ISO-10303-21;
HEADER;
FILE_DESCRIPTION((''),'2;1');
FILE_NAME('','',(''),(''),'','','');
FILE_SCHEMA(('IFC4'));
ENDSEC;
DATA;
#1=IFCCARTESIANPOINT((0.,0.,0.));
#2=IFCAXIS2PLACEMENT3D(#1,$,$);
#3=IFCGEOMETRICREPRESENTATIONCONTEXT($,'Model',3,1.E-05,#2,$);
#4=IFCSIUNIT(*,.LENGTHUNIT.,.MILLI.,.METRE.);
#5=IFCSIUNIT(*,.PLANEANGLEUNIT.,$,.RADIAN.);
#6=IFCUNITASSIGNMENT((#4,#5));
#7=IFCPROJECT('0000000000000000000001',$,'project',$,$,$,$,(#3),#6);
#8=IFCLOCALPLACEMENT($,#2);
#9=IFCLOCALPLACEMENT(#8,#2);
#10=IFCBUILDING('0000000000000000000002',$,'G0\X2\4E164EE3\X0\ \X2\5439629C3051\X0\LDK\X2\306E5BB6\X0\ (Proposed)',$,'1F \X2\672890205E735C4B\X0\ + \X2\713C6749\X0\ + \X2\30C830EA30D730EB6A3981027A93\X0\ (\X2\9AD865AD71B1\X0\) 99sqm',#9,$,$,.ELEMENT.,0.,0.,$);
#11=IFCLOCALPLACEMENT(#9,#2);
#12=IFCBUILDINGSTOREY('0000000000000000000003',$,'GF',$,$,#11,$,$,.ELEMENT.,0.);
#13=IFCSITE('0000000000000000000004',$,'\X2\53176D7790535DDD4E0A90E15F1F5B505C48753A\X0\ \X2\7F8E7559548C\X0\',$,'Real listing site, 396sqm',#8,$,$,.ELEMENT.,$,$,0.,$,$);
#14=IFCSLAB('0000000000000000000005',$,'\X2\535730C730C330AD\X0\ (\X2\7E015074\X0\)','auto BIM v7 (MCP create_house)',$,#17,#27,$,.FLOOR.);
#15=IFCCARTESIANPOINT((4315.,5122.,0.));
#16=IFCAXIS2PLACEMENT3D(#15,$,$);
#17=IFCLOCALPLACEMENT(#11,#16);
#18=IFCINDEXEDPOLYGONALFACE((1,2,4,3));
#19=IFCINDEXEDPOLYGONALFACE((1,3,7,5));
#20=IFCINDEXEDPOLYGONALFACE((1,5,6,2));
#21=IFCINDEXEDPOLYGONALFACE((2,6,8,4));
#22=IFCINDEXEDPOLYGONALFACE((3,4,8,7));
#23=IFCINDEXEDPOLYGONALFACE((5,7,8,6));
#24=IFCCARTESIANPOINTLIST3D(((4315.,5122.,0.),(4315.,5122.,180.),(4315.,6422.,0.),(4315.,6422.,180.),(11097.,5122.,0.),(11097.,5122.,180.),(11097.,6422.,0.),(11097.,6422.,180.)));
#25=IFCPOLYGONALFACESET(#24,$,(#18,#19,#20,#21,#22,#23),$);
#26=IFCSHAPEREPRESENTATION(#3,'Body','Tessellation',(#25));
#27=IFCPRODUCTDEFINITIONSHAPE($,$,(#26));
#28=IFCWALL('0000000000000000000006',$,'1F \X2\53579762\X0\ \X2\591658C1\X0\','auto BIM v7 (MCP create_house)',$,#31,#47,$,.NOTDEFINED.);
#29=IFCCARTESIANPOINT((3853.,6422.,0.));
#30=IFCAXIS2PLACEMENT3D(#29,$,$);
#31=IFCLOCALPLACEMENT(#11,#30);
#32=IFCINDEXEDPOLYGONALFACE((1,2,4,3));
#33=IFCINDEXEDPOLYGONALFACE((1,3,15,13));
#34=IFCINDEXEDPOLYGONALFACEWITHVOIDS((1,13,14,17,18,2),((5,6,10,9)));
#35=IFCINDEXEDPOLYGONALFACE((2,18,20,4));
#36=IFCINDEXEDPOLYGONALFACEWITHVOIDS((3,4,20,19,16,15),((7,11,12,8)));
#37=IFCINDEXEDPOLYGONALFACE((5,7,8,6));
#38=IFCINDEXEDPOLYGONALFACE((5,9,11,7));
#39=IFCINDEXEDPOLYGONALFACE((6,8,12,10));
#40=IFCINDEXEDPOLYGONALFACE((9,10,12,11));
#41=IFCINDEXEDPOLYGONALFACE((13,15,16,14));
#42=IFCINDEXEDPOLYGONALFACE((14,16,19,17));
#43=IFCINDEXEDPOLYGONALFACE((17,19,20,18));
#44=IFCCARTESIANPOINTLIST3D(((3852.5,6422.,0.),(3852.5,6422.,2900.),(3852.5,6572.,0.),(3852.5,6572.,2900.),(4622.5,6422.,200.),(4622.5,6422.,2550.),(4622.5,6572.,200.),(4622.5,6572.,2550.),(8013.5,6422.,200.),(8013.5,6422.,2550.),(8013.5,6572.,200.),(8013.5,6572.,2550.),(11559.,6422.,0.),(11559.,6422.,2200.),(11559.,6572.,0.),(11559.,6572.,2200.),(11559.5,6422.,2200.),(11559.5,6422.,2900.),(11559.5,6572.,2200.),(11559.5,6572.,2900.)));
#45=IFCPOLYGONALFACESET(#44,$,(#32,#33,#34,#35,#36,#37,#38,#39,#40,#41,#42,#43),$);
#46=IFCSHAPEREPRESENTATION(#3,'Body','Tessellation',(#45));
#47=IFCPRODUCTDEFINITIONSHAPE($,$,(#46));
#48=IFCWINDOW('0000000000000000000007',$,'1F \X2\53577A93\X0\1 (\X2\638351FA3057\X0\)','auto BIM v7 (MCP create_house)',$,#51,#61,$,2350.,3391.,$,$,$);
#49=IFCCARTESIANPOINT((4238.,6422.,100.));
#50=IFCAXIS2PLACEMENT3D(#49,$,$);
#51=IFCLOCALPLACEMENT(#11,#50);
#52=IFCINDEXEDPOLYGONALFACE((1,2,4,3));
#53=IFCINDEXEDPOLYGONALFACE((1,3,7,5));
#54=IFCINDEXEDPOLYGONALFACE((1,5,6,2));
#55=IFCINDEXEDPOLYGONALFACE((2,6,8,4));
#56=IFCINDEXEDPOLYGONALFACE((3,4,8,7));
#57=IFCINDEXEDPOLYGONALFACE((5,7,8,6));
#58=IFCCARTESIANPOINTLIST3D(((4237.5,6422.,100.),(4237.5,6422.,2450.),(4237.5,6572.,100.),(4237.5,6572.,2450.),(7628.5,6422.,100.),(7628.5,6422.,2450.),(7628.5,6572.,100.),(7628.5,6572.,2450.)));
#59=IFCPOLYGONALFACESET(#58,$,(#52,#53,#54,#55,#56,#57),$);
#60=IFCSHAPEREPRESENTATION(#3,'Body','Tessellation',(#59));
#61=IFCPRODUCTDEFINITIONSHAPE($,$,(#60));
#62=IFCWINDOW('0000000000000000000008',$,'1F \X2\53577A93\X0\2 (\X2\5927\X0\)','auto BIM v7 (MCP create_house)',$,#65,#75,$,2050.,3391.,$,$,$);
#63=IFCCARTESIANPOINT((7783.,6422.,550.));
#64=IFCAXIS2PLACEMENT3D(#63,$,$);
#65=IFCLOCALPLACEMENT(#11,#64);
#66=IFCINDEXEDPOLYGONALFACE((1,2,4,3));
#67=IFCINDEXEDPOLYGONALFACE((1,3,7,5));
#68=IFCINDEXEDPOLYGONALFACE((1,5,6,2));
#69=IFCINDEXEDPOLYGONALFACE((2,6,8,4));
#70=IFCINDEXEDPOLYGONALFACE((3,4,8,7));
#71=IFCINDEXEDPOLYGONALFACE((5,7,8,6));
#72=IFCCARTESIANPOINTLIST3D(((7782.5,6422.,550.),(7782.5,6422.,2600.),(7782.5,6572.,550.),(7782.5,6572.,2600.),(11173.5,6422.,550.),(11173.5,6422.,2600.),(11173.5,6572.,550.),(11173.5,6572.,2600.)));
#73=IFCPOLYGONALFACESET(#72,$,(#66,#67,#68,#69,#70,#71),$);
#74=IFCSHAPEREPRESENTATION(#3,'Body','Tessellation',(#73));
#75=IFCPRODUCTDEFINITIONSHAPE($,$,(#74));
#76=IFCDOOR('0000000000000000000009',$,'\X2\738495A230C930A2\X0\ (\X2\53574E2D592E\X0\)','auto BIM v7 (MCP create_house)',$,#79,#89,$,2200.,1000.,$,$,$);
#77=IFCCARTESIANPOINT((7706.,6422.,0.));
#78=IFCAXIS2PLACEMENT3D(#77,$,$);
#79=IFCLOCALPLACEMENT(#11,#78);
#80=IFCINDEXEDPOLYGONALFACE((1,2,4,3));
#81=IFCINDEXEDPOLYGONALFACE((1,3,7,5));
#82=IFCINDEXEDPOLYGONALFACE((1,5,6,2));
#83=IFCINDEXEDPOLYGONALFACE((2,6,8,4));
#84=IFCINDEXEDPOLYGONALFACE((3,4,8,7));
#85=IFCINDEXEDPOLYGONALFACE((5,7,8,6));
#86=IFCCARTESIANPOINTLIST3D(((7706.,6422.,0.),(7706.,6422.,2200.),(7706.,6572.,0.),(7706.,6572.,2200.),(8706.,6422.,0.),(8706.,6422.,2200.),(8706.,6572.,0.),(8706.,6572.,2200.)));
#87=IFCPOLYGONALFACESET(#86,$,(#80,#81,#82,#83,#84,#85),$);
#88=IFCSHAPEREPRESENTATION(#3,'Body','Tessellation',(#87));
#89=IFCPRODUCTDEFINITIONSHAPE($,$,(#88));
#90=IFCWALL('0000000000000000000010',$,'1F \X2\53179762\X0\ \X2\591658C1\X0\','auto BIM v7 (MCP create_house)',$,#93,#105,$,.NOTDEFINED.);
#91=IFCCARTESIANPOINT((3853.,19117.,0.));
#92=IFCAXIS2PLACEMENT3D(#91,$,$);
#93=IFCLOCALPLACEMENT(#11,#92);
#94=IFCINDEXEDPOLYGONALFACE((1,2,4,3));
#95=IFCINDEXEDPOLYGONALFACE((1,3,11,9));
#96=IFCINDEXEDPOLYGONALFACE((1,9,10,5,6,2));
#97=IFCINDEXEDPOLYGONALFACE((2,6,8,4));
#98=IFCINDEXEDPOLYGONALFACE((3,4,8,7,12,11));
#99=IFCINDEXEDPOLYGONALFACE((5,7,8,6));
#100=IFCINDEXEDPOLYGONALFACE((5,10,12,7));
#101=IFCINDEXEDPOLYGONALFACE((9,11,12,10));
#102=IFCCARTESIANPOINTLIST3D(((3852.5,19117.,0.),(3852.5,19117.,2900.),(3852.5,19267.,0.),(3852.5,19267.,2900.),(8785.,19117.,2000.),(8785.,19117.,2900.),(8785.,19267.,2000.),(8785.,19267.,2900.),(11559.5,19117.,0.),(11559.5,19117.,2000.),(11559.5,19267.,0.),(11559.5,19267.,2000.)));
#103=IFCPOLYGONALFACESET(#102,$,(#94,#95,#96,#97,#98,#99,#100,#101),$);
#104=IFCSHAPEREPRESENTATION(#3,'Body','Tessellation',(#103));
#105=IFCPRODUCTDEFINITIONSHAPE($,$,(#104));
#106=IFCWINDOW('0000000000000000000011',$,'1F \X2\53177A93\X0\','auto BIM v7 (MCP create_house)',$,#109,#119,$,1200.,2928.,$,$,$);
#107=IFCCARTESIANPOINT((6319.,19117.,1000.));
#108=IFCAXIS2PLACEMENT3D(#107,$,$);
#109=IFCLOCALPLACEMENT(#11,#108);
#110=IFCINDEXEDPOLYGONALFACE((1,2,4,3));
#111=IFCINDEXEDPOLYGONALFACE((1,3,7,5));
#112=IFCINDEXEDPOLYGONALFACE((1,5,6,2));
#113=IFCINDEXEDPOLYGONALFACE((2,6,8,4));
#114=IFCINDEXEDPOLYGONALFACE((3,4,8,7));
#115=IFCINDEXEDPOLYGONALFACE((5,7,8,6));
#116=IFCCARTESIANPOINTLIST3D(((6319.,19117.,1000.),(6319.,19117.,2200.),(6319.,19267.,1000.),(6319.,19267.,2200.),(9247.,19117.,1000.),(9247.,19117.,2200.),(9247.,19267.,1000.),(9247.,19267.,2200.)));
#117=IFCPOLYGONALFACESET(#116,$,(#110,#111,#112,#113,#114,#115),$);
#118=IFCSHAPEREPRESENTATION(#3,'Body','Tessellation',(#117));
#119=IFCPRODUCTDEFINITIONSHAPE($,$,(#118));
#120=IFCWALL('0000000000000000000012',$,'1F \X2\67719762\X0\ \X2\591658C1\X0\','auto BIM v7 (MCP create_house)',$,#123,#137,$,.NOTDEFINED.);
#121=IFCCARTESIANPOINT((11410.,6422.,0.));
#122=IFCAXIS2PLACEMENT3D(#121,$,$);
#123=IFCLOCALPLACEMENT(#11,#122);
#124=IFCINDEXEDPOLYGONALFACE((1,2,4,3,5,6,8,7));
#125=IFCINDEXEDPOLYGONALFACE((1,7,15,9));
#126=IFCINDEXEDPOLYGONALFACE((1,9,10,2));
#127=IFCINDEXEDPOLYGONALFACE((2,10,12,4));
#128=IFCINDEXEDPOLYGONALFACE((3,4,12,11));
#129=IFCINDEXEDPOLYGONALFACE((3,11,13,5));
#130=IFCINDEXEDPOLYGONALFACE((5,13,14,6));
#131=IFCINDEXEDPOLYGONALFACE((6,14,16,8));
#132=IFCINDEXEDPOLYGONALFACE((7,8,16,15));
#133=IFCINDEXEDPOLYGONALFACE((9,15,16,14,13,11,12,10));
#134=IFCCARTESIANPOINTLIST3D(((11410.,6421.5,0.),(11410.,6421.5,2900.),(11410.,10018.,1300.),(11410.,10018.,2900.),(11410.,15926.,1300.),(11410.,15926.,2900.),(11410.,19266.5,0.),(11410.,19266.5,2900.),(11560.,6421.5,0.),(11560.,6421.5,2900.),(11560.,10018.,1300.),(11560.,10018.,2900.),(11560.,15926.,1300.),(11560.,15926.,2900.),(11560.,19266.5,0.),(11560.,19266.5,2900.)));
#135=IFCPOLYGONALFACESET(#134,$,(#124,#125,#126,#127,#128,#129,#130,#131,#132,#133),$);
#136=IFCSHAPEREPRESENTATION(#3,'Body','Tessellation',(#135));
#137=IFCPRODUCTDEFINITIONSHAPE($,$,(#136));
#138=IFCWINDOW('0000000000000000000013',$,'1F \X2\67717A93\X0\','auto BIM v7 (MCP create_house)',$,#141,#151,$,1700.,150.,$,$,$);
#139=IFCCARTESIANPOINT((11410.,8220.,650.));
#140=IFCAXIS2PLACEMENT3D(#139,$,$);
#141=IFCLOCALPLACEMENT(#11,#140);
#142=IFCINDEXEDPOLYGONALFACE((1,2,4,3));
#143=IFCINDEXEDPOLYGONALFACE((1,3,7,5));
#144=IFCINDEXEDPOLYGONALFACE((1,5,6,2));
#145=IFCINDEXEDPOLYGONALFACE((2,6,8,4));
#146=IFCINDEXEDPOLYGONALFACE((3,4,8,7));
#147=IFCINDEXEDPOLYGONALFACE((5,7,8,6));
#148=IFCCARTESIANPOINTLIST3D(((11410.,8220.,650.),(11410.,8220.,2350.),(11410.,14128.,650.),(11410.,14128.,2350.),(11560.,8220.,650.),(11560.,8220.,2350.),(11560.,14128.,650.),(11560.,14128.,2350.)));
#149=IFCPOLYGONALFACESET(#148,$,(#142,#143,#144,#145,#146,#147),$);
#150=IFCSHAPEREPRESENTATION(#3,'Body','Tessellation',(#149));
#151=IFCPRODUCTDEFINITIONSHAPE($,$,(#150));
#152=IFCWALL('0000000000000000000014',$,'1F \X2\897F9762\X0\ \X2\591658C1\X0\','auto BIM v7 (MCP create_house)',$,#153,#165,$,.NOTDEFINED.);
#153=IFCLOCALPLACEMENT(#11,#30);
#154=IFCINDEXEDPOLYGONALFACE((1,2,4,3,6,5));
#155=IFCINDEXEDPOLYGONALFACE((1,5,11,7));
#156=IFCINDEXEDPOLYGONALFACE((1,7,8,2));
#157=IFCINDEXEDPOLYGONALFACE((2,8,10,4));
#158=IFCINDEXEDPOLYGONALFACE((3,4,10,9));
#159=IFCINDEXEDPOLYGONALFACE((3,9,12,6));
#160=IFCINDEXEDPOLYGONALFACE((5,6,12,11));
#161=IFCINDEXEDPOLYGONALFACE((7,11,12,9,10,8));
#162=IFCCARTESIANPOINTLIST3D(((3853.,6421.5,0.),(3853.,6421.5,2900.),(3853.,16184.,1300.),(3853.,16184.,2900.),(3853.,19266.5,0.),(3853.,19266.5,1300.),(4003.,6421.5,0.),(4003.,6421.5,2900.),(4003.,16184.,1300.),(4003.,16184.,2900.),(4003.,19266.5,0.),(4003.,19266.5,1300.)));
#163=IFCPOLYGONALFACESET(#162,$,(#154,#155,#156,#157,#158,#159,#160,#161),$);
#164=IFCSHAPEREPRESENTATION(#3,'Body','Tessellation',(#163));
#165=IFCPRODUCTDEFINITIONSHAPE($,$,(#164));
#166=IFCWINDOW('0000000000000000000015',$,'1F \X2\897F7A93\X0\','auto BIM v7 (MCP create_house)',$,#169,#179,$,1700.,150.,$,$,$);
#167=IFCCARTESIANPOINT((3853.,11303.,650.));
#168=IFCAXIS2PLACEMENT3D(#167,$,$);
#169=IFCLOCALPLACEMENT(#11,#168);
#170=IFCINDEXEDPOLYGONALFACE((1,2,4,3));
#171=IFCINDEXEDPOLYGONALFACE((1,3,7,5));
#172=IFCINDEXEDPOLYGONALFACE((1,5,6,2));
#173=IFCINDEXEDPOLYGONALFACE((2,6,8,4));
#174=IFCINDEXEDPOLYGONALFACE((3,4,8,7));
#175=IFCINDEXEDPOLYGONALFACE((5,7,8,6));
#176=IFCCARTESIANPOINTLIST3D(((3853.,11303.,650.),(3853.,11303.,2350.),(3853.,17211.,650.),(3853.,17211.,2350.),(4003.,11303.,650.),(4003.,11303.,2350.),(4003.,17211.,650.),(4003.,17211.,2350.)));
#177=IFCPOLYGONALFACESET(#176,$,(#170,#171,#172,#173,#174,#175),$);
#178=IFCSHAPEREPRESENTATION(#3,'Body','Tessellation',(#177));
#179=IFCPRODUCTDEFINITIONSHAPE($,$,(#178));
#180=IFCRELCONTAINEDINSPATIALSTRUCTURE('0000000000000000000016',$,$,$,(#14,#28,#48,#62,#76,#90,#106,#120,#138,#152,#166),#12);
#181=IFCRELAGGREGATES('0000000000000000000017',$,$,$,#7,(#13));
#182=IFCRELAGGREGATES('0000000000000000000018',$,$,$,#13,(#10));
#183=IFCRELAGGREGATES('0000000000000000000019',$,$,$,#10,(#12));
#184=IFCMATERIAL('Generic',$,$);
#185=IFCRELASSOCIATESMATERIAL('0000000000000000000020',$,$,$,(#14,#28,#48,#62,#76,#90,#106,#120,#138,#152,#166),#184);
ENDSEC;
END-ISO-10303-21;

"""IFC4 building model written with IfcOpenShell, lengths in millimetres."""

from ifc_helpers import new_model, si_unit, frame, frame_2d, origin, place, context, project, spatial, rectangle, extrude, material, element, fill, save


model = new_model("IFC4")

# Units and contexts
model_context = context("Model", 3, precision=1e-05, world=origin())
ifc_project = project(units=[si_unit("LENGTHUNIT", "METRE", prefix="MILLI"), si_unit("PLANEANGLEUNIT", "RADIAN")], contexts=[model_context])

# Site, building, storey
site_placement = place(None, origin())
site = spatial("IfcSite", under=ifc_project, at=site_placement, Name="北海道川上郡弟子屈町 美留和", ObjectType="Real listing site, 396sqm", CompositionType="ELEMENT", RefElevation=0.0)
building_placement = place(site_placement, origin())
building = spatial("IfcBuilding", under=site, at=building_placement, Name="G0世代 吹抜けLDKの家 (Proposed)", ObjectType="1F 木造平屋 + 焼杉 + トリプル樹脂窓 (高断熱) 99sqm", CompositionType="ELEMENT", ElevationOfRefHeight=0.0, ElevationOfTerrain=0.0)
storey_placement = place(building_placement, origin())
storey = spatial("IfcBuildingStorey", under=building, at=storey_placement, Name="GF", CompositionType="ELEMENT", Elevation=0.0)

# Slab
ifc_material = material(Name="Generic")
slab_1_placement = place(storey_placement, frame((4315.0, 5122.0, 0.0)))
element("IfcSlab", 1, at=slab_1_placement, inside=storey, material=ifc_material, Name="南デッキ (縁側)", Description="auto BIM v7 (MCP create_house)", PredefinedType="FLOOR", context=model_context, shape_type="SweptSolid", body=[
    extrude(rectangle(XDim=6782.0, YDim=1300.0, at=frame_2d((3391.0, 650.0))), frame((4315.0, 5122.0, 0.0)), (0.0, 0.0, 1.0), 180.0),
])

# Wall, openings, windows, door
wall_1_placement = place(storey_placement, frame((3853.0, 6422.0, 0.0)))
wall_1 = element("IfcWall", 2, at=wall_1_placement, inside=storey, material=ifc_material, Name="1F 南面 外壁", Description="auto BIM v7 (MCP create_house)", PredefinedType="NOTDEFINED", context=model_context, shape_type="SweptSolid", body=[
    extrude(rectangle(XDim=7707.0, YDim=150.0, at=frame_2d((3853.0, 75.0))), frame((3853.0, 6422.0, 0.0)), (0.0, 0.0, 1.0), 2900.0),
])
opening_1_placement = place(storey_placement, frame((4238.0, 6422.0, 100.0)))
opening_1 = element("IfcOpeningElement", 3, at=opening_1_placement, cuts=wall_1, PredefinedType="NOTDEFINED", context=model_context, shape_type="SweptSolid", body=[
    extrude(rectangle(XDim=3391.0, YDim=150.0, at=frame_2d((1695.0, 75.0))), frame((4238.0, 6422.0, 100.0)), (0.0, 0.0, 1.0), 2350.0),
])
opening_2_placement = place(storey_placement, frame((7783.0, 6422.0, 550.0)))
opening_2 = element("IfcOpeningElement", 4, at=opening_2_placement, cuts=wall_1, PredefinedType="NOTDEFINED", context=model_context, shape_type="SweptSolid", body=[
    extrude(rectangle(XDim=3391.0, YDim=150.0, at=frame_2d((1695.0, 75.0))), frame((7783.0, 6422.0, 550.0)), (0.0, 0.0, 1.0), 2050.0),
])
opening_3_placement = place(storey_placement, frame((7706.0, 6422.0, 0.0)))
opening_3 = element("IfcOpeningElement", 5, at=opening_3_placement, cuts=wall_1, PredefinedType="NOTDEFINED", context=model_context, shape_type="SweptSolid", body=[
    extrude(rectangle(XDim=1000.0, YDim=150.0, at=frame_2d((500.0, 75.0))), frame((7706.0, 6422.0, 0.0)), (0.0, 0.0, 1.0), 2200.0),
])
window_1_placement = place(storey_placement, frame((4238.0, 6422.0, 100.0)))
window_1 = element("IfcWindow", 6, at=window_1_placement, inside=storey, material=ifc_material, Name="1F 南窓1 (掃出し)", Description="auto BIM v7 (MCP create_house)", OverallHeight=2350.0, OverallWidth=3391.0, context=model_context, shape_type="SweptSolid", body=[
    extrude(rectangle(XDim=3391.0, YDim=150.0, at=frame_2d((1695.0, 75.0))), frame((4238.0, 6422.0, 100.0)), (0.0, 0.0, 1.0), 2350.0),
])
fill(opening_1, window_1)
window_2_placement = place(storey_placement, frame((7783.0, 6422.0, 550.0)))
window_2 = element("IfcWindow", 7, at=window_2_placement, inside=storey, material=ifc_material, Name="1F 南窓2 (大)", Description="auto BIM v7 (MCP create_house)", OverallHeight=2050.0, OverallWidth=3391.0, context=model_context, shape_type="SweptSolid", body=[
    extrude(rectangle(XDim=3391.0, YDim=150.0, at=frame_2d((1695.0, 75.0))), frame((7783.0, 6422.0, 550.0)), (0.0, 0.0, 1.0), 2050.0),
])
fill(opening_2, window_2)
door_placement = place(storey_placement, frame((7706.0, 6422.0, 0.0)))
door = element("IfcDoor", 8, at=door_placement, inside=storey, material=ifc_material, Name="玄関ドア (南中央)", Description="auto BIM v7 (MCP create_house)", OverallHeight=2200.0, OverallWidth=1000.0, context=model_context, shape_type="SweptSolid", body=[
    extrude(rectangle(XDim=1000.0, YDim=150.0, at=frame_2d((500.0, 75.0))), frame((7706.0, 6422.0, 0.0)), (0.0, 0.0, 1.0), 2200.0),
])
fill(opening_3, door)

# Walls, openings, windows
wall_2_placement = place(storey_placement, frame((3853.0, 19117.0, 0.0)))
wall_2 = element("IfcWall", 9, at=wall_2_placement, inside=storey, material=ifc_material, Name="1F 北面 外壁", Description="auto BIM v7 (MCP create_house)", PredefinedType="NOTDEFINED", context=model_context, shape_type="SweptSolid", body=[
    extrude(rectangle(XDim=7707.0, YDim=150.0, at=frame_2d((3853.0, 75.0))), frame((3853.0, 19117.0, 0.0)), (0.0, 0.0, 1.0), 2900.0),
])
opening_4_placement = place(storey_placement, frame((6319.0, 19117.0, 1000.0)))
opening_4 = element("IfcOpeningElement", 10, at=opening_4_placement, cuts=wall_2, PredefinedType="NOTDEFINED", context=model_context, shape_type="SweptSolid", body=[
    extrude(rectangle(XDim=2928.0, YDim=150.0, at=frame_2d((1464.0, 75.0))), frame((6319.0, 19117.0, 1000.0)), (0.0, 0.0, 1.0), 1200.0),
])
window_3_placement = place(storey_placement, frame((6319.0, 19117.0, 1000.0)))
window_3 = element("IfcWindow", 11, at=window_3_placement, inside=storey, material=ifc_material, Name="1F 北窓", Description="auto BIM v7 (MCP create_house)", OverallHeight=1200.0, OverallWidth=2928.0, context=model_context, shape_type="SweptSolid", body=[
    extrude(rectangle(XDim=2928.0, YDim=150.0, at=frame_2d((1464.0, 75.0))), frame((6319.0, 19117.0, 1000.0)), (0.0, 0.0, 1.0), 1200.0),
])
fill(opening_4, window_3)
wall_3_placement = place(storey_placement, frame((11410.0, 6422.0, 0.0)))
wall_3 = element("IfcWall", 12, at=wall_3_placement, inside=storey, material=ifc_material, Name="1F 東面 外壁", Description="auto BIM v7 (MCP create_house)", PredefinedType="NOTDEFINED", context=model_context, shape_type="SweptSolid", body=[
    extrude(rectangle(XDim=150.0, YDim=12845.0, at=frame_2d((75.0, 6422.0))), frame((11410.0, 6422.0, 0.0)), (0.0, 0.0, 1.0), 2900.0),
])
opening_5_placement = place(storey_placement, frame((11410.0, 8220.0, 650.0)))
opening_5 = element("IfcOpeningElement", 13, at=opening_5_placement, cuts=wall_3, PredefinedType="NOTDEFINED", context=model_context, shape_type="SweptSolid", body=[
    extrude(rectangle(XDim=150.0, YDim=5908.0, at=frame_2d((75.0, 2954.0))), frame((11410.0, 8220.0, 650.0)), (0.0, 0.0, 1.0), 1700.0),
])
window_4_placement = place(storey_placement, frame((11410.0, 8220.0, 650.0)))
window_4 = element("IfcWindow", 14, at=window_4_placement, inside=storey, material=ifc_material, Name="1F 東窓", Description="auto BIM v7 (MCP create_house)", OverallHeight=1700.0, OverallWidth=150.0, context=model_context, shape_type="SweptSolid", body=[
    extrude(rectangle(XDim=150.0, YDim=5908.0, at=frame_2d((75.0, 2954.0))), frame((11410.0, 8220.0, 650.0)), (0.0, 0.0, 1.0), 1700.0),
])
fill(opening_5, window_4)
wall_4_placement = place(storey_placement, frame((3853.0, 6422.0, 0.0)))
wall_4 = element("IfcWall", 15, at=wall_4_placement, inside=storey, material=ifc_material, Name="1F 西面 外壁", Description="auto BIM v7 (MCP create_house)", PredefinedType="NOTDEFINED", context=model_context, shape_type="SweptSolid", body=[
    extrude(rectangle(XDim=150.0, YDim=12845.0, at=frame_2d((75.0, 6422.0))), frame((3853.0, 6422.0, 0.0)), (0.0, 0.0, 1.0), 2900.0),
])
opening_6_placement = place(storey_placement, frame((3853.0, 11303.0, 650.0)))
opening_6 = element("IfcOpeningElement", 16, at=opening_6_placement, cuts=wall_4, PredefinedType="NOTDEFINED", context=model_context, shape_type="SweptSolid", body=[
    extrude(rectangle(XDim=150.0, YDim=5908.0, at=frame_2d((75.0, 2954.0))), frame((3853.0, 11303.0, 650.0)), (0.0, 0.0, 1.0), 1700.0),
])
window_5_placement = place(storey_placement, frame((3853.0, 11303.0, 650.0)))
window_5 = element("IfcWindow", 17, at=window_5_placement, inside=storey, material=ifc_material, Name="1F 西窓", Description="auto BIM v7 (MCP create_house)", OverallHeight=1700.0, OverallWidth=150.0, context=model_context, shape_type="SweptSolid", body=[
    extrude(rectangle(XDim=150.0, YDim=5908.0, at=frame_2d((75.0, 2954.0))), frame((3853.0, 11303.0, 650.0)), (0.0, 0.0, 1.0), 1700.0),
])
fill(opening_6, window_5)

save(model, "model.ifc")
